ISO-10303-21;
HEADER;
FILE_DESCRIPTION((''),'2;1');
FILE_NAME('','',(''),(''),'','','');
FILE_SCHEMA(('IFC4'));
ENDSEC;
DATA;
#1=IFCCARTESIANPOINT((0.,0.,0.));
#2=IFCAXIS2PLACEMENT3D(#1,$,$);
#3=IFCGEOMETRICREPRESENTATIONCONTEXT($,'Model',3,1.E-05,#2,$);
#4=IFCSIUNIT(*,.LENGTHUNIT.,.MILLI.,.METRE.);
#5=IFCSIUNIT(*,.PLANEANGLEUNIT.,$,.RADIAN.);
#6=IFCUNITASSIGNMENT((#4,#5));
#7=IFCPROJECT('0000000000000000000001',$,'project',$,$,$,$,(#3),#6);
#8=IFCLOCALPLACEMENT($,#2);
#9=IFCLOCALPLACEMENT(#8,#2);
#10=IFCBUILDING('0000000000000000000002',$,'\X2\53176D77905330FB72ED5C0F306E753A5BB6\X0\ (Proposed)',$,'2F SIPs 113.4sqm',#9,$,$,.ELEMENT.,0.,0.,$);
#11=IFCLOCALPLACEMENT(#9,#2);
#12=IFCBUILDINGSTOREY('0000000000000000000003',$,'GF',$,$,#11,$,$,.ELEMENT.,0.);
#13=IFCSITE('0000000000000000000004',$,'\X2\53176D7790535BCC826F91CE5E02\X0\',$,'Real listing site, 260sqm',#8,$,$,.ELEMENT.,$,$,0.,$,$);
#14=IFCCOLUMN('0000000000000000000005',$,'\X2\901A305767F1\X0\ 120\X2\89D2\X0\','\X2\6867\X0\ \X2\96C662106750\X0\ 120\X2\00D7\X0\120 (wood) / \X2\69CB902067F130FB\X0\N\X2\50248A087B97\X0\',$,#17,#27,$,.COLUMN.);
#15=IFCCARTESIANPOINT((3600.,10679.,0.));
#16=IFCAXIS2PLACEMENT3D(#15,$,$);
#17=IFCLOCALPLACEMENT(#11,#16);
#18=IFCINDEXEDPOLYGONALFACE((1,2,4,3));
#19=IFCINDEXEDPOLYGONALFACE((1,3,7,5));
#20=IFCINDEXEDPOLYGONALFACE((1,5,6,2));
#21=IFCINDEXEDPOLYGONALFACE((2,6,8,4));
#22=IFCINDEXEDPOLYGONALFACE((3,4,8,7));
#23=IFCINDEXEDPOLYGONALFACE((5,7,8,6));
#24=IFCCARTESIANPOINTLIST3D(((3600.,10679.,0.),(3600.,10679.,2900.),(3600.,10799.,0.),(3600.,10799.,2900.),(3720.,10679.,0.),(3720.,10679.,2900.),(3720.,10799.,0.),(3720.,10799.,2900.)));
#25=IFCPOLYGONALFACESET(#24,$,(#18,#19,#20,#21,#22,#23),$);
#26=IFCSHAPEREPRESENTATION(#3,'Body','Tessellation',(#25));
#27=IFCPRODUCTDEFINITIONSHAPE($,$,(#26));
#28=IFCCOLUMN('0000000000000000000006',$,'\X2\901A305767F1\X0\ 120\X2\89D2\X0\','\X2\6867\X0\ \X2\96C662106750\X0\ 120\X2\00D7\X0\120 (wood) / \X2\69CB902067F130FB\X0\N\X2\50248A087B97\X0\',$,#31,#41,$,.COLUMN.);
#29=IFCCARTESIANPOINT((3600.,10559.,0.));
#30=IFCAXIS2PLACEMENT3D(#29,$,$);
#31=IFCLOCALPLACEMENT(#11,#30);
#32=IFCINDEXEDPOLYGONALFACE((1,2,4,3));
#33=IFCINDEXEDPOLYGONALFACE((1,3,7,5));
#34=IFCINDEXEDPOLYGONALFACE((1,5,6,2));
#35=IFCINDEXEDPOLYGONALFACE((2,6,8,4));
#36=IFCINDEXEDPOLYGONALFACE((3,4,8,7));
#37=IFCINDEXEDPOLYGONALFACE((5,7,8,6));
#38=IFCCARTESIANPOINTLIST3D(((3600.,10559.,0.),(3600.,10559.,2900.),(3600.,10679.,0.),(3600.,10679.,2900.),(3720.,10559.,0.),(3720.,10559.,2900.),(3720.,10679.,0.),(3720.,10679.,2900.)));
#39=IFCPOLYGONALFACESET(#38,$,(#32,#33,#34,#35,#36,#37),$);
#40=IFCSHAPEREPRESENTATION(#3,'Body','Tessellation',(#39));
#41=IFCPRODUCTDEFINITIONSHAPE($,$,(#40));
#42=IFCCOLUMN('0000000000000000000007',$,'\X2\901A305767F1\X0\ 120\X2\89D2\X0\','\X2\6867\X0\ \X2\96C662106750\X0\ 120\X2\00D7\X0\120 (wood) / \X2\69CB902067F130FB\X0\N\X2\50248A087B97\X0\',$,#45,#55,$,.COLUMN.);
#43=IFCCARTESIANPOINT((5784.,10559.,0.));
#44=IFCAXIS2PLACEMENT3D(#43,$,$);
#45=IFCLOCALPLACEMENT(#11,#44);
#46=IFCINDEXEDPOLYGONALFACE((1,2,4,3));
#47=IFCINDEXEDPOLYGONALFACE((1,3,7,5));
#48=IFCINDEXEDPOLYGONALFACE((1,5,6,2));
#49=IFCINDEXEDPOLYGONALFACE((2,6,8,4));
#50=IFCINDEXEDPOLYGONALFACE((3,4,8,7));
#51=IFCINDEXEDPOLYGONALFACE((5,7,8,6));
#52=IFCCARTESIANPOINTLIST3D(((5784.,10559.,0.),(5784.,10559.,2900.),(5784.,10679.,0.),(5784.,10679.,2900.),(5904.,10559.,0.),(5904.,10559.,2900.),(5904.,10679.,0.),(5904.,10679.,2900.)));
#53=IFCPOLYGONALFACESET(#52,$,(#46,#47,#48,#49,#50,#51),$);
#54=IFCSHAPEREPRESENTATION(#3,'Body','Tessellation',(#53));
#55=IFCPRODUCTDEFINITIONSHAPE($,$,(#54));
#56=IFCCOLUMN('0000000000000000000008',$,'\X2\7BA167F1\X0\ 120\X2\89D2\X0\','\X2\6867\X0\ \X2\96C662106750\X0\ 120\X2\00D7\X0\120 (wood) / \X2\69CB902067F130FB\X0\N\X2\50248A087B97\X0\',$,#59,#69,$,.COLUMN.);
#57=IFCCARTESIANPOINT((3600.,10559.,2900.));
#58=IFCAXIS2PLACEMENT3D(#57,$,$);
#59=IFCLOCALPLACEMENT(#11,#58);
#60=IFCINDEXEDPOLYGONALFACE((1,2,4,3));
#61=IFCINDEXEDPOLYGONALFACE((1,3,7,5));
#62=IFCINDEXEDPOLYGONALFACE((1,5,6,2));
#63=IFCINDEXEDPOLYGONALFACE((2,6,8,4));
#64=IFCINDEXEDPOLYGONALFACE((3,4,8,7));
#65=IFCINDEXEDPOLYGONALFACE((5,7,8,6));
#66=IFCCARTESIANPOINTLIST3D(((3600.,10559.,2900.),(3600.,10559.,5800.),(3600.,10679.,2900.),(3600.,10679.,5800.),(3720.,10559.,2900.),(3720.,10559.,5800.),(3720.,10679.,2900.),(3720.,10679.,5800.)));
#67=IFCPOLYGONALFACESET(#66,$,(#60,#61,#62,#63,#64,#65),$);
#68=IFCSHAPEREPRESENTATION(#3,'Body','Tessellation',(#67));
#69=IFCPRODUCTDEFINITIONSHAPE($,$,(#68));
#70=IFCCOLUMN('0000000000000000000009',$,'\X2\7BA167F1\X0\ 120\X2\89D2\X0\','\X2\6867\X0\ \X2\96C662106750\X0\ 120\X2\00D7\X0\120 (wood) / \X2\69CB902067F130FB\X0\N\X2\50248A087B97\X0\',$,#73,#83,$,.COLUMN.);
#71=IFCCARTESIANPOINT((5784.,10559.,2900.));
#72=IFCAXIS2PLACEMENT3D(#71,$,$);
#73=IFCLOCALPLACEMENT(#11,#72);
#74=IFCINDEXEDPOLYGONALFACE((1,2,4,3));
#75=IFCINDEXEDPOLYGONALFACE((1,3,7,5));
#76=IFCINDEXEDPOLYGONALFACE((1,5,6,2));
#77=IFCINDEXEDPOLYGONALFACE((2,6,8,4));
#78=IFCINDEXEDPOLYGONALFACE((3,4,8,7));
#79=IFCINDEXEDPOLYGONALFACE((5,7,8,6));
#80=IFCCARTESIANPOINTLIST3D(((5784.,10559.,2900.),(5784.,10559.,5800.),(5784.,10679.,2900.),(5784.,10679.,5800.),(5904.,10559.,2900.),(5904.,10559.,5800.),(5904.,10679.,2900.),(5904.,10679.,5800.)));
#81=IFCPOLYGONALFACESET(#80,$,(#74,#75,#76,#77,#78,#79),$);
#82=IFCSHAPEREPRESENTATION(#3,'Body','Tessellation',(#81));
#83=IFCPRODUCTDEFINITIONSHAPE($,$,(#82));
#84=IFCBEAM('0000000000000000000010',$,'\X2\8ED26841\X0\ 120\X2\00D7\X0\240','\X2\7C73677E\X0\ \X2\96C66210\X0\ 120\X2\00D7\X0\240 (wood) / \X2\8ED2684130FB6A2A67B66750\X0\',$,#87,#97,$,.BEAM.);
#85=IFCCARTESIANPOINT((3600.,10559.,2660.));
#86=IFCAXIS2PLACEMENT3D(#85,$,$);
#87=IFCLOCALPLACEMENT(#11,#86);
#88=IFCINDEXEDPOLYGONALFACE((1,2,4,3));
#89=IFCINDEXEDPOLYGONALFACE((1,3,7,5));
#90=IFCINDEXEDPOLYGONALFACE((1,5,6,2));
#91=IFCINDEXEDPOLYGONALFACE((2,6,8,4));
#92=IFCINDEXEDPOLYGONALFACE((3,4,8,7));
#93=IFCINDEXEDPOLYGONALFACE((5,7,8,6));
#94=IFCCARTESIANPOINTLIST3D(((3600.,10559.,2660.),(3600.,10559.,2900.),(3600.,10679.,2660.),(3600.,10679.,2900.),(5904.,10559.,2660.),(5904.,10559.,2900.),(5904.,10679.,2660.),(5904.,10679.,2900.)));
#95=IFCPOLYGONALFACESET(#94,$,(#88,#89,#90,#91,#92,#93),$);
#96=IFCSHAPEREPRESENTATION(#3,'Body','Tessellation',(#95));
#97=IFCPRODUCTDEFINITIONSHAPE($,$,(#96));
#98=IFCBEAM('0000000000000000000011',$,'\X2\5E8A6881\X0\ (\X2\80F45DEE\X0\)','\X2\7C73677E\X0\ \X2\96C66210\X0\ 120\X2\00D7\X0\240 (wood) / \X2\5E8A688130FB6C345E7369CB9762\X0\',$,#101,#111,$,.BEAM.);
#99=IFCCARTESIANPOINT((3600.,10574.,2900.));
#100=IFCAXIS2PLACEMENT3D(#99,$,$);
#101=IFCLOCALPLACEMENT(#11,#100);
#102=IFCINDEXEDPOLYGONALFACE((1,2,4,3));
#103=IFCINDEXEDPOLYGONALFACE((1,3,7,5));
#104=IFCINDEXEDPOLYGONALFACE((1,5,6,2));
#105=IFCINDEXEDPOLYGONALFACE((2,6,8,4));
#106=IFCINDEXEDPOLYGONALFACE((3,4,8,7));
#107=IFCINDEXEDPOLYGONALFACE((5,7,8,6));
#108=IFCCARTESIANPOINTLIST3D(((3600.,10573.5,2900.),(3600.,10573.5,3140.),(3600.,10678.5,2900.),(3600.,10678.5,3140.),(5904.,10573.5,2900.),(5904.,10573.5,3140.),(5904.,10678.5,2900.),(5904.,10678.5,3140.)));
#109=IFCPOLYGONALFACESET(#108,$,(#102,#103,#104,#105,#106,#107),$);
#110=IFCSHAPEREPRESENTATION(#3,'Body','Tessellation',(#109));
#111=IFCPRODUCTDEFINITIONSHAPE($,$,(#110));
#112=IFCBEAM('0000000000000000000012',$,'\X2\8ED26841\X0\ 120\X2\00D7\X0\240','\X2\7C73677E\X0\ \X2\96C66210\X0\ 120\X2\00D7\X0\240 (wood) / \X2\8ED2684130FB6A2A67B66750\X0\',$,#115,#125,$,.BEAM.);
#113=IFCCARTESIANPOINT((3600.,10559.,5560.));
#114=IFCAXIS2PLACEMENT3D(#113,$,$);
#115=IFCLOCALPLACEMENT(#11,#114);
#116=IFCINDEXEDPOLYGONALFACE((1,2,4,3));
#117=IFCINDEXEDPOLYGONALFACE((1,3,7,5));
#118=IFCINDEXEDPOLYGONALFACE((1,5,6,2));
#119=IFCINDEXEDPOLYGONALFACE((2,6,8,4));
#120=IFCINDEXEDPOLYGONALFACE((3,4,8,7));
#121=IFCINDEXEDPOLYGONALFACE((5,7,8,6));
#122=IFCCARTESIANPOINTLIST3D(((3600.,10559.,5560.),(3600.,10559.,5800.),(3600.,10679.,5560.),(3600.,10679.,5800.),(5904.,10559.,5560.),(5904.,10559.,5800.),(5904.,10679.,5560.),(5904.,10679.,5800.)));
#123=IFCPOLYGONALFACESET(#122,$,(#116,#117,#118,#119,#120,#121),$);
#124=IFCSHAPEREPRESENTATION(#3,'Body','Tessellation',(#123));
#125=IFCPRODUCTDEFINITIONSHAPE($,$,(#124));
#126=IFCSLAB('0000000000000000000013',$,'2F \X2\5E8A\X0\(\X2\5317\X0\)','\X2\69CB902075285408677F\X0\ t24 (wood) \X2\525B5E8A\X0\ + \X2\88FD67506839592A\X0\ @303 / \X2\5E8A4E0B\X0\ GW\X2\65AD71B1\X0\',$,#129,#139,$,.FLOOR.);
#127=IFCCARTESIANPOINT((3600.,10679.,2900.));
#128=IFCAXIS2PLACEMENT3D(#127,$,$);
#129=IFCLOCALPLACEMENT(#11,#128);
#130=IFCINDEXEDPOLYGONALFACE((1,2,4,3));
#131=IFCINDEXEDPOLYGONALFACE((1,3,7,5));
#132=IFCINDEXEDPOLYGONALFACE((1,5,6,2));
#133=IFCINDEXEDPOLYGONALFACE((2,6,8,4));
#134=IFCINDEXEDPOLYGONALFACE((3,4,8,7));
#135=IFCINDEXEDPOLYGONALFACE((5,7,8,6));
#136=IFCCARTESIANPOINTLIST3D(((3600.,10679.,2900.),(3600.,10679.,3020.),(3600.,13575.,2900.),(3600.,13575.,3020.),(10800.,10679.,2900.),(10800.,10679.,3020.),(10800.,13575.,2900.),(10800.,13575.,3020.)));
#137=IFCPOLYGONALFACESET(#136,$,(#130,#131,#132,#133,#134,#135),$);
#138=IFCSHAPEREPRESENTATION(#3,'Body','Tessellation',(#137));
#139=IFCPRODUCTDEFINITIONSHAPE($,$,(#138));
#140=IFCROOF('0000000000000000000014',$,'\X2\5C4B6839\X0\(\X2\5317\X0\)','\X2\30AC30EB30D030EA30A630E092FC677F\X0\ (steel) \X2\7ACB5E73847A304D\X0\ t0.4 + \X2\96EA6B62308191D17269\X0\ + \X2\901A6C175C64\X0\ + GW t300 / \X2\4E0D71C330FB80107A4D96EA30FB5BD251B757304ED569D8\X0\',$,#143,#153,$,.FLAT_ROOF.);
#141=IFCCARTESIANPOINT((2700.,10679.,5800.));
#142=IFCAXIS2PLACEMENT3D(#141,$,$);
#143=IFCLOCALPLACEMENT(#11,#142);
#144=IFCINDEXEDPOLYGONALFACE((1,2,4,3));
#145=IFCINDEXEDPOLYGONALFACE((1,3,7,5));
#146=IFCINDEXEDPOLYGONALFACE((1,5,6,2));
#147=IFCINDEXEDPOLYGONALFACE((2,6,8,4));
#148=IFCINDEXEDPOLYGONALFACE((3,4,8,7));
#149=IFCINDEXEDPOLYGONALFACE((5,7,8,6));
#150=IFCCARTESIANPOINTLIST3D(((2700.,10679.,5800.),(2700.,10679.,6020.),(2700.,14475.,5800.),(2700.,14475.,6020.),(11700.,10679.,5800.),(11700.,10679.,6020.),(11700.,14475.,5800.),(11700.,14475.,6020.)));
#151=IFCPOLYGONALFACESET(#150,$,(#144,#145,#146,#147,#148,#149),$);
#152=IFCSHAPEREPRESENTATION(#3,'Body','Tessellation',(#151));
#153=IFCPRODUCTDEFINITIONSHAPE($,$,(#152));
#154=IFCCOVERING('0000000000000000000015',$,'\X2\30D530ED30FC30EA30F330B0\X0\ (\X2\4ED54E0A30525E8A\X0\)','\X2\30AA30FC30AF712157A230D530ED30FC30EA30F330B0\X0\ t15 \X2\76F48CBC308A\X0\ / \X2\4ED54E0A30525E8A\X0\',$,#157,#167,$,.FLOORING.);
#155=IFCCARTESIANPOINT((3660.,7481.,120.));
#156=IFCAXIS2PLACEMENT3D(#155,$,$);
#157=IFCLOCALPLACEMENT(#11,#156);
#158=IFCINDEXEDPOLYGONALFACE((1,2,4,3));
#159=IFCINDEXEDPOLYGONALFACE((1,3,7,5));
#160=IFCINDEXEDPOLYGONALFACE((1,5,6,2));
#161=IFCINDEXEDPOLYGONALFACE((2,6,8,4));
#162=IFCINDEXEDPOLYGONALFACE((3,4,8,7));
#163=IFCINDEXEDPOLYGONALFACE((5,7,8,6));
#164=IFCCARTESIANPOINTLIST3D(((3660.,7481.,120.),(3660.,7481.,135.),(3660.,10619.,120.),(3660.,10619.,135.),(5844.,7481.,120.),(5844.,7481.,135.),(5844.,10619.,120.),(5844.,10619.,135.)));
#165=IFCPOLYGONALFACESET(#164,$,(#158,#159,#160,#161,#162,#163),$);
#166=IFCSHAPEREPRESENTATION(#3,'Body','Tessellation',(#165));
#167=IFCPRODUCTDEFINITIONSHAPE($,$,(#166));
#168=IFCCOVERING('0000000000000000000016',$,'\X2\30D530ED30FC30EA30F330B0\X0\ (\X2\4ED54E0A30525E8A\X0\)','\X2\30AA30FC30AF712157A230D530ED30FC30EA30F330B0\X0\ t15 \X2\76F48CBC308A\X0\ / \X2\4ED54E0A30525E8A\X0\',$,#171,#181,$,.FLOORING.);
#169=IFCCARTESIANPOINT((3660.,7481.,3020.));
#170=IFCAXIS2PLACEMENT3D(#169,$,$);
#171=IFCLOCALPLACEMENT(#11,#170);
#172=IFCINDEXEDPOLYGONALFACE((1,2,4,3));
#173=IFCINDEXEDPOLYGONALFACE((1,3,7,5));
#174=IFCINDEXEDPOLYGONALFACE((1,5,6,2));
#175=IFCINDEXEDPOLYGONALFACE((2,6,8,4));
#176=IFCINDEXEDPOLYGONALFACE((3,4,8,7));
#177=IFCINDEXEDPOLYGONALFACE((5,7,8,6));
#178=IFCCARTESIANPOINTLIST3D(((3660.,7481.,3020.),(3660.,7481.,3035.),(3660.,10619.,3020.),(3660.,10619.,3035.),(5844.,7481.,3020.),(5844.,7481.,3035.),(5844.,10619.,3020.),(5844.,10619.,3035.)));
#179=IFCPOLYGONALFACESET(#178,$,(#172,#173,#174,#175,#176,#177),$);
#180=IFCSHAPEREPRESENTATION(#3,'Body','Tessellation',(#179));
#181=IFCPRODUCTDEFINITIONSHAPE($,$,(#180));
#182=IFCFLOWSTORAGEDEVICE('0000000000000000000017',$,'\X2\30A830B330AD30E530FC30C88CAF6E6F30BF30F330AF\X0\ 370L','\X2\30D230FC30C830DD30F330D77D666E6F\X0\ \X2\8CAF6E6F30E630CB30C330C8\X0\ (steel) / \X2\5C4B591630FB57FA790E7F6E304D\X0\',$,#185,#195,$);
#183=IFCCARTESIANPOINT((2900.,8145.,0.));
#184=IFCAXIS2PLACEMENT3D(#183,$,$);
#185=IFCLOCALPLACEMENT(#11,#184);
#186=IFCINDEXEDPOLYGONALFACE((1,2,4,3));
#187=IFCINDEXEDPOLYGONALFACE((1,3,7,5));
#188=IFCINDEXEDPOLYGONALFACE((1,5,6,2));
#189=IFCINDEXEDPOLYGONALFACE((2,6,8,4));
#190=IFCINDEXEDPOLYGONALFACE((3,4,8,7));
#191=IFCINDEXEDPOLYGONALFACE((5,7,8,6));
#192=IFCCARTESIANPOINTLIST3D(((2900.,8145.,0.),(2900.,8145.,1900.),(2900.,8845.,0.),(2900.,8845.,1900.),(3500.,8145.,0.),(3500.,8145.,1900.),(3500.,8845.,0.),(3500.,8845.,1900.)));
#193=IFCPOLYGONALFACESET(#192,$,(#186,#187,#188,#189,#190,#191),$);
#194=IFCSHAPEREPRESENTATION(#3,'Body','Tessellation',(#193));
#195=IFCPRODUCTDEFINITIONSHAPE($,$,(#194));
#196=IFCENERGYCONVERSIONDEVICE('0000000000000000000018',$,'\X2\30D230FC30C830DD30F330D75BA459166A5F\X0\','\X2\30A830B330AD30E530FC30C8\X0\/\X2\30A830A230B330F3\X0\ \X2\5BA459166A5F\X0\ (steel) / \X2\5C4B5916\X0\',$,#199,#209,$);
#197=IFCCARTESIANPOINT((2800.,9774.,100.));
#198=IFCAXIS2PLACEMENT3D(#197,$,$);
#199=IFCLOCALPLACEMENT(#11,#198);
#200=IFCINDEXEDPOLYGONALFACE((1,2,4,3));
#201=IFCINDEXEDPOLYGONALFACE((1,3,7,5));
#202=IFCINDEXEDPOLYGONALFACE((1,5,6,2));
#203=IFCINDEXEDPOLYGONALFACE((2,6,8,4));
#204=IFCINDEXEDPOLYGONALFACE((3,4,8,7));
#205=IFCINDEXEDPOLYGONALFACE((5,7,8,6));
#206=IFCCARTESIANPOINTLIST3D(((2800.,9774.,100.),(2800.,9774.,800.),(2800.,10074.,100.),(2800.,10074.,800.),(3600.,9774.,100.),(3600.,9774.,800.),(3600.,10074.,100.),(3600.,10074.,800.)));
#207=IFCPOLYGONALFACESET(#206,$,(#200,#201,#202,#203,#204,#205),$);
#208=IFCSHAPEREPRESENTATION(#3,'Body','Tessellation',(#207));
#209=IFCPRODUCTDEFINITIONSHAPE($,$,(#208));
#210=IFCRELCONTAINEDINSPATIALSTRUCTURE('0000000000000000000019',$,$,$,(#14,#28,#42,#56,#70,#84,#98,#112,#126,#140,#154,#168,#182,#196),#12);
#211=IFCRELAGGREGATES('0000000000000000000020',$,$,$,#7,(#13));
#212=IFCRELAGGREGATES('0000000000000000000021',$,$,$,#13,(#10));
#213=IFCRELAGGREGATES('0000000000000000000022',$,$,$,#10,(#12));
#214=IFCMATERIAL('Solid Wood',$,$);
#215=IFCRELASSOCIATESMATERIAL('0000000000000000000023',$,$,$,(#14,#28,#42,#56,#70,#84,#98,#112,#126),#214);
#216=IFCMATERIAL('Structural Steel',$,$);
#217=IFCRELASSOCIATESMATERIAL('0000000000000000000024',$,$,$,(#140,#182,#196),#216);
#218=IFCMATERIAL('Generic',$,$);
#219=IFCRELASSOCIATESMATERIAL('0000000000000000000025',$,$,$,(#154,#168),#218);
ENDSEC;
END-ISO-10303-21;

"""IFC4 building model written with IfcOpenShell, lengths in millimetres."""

from ifc_helpers import new_model, si_unit, frame, frame_2d, origin, place, context, project, spatial, rectangle, extrude, material, element, save


model = new_model("IFC4")

# Units and contexts
model_context = context("Model", 3, precision=1e-05, world=origin())
ifc_project = project(units=[si_unit("LENGTHUNIT", "METRE", prefix="MILLI"), si_unit("PLANEANGLEUNIT", "RADIAN")], contexts=[model_context])

# Site, building, storey
site_placement = place(None, origin())
site = spatial("IfcSite", under=ifc_project, at=site_placement, Name="北海道富良野市", ObjectType="Real listing site, 260sqm", CompositionType="ELEMENT", RefElevation=0.0)
building_placement = place(site_placement, origin())
building = spatial("IfcBuilding", under=site, at=building_placement, Name="北海道・狭小の町家 (Proposed)", ObjectType="2F SIPs 113.4sqm", CompositionType="ELEMENT", ElevationOfRefHeight=0.0, ElevationOfTerrain=0.0)
storey_placement = place(building_placement, origin())
storey = spatial("IfcBuildingStorey", under=building, at=storey_placement, Name="GF", CompositionType="ELEMENT", Elevation=0.0)

# Columns
ifc_material_1 = material(Name="Solid Wood")
column_1_placement = place(storey_placement, frame((3600.0, 10679.0, 0.0)))
element("IfcColumn", 1, at=column_1_placement, inside=storey, material=ifc_material_1, Name="通し柱 120角", Description="桧 集成材 120×120 (wood) / 構造柱・N値計算", PredefinedType="COLUMN", context=model_context, shape_type="SweptSolid", body=[
    extrude(rectangle(XDim=120.0, YDim=120.0, at=frame_2d((60.0, 60.0))), frame((3600.0, 10679.0, 0.0)), (0.0, 0.0, 1.0), 2900.0),
])
column_2_placement = place(storey_placement, frame((3600.0, 10559.0, 0.0)))
element("IfcColumn", 2, at=column_2_placement, inside=storey, material=ifc_material_1, Name="通し柱 120角", Description="桧 集成材 120×120 (wood) / 構造柱・N値計算", PredefinedType="COLUMN", context=model_context, shape_type="SweptSolid", body=[
    extrude(rectangle(XDim=120.0, YDim=120.0, at=frame_2d((60.0, 60.0))), frame((3600.0, 10559.0, 0.0)), (0.0, 0.0, 1.0), 2900.0),
])
column_3_placement = place(storey_placement, frame((5784.0, 10559.0, 0.0)))
element("IfcColumn", 3, at=column_3_placement, inside=storey, material=ifc_material_1, Name="通し柱 120角", Description="桧 集成材 120×120 (wood) / 構造柱・N値計算", PredefinedType="COLUMN", context=model_context, shape_type="SweptSolid", body=[
    extrude(rectangle(XDim=120.0, YDim=120.0, at=frame_2d((60.0, 60.0))), frame((5784.0, 10559.0, 0.0)), (0.0, 0.0, 1.0), 2900.0),
])
column_4_placement = place(storey_placement, frame((3600.0, 10559.0, 2900.0)))
element("IfcColumn", 4, at=column_4_placement, inside=storey, material=ifc_material_1, Name="管柱 120角", Description="桧 集成材 120×120 (wood) / 構造柱・N値計算", PredefinedType="COLUMN", context=model_context, shape_type="SweptSolid", body=[
    extrude(rectangle(XDim=120.0, YDim=120.0, at=frame_2d((60.0, 60.0))), frame((3600.0, 10559.0, 2900.0)), (0.0, 0.0, 1.0), 2900.0),
])
column_5_placement = place(storey_placement, frame((5784.0, 10559.0, 2900.0)))
element("IfcColumn", 5, at=column_5_placement, inside=storey, material=ifc_material_1, Name="管柱 120角", Description="桧 集成材 120×120 (wood) / 構造柱・N値計算", PredefinedType="COLUMN", context=model_context, shape_type="SweptSolid", body=[
    extrude(rectangle(XDim=120.0, YDim=120.0, at=frame_2d((60.0, 60.0))), frame((5784.0, 10559.0, 2900.0)), (0.0, 0.0, 1.0), 2900.0),
])

# Beams
beam_1_placement = place(storey_placement, frame((3600.0, 10559.0, 2660.0)))
element("IfcBeam", 6, at=beam_1_placement, inside=storey, material=ifc_material_1, Name="軒桁 120×240", Description="米松 集成 120×240 (wood) / 軒桁・横架材", PredefinedType="BEAM", context=model_context, shape_type="SweptSolid", body=[
    extrude(rectangle(XDim=2304.0, YDim=120.0, at=frame_2d((1152.0, 60.0))), frame((3600.0, 10559.0, 2660.0)), (0.0, 0.0, 1.0), 240.0),
])
beam_2_placement = place(storey_placement, frame((3600.0, 10574.0, 2900.0)))
element("IfcBeam", 7, at=beam_2_placement, inside=storey, material=ifc_material_1, Name="床梁 (胴差)", Description="米松 集成 120×240 (wood) / 床梁・水平構面", PredefinedType="BEAM", context=model_context, shape_type="SweptSolid", body=[
    extrude(rectangle(XDim=2304.0, YDim=105.0, at=frame_2d((1152.0, 52.0))), frame((3600.0, 10574.0, 2900.0)), (0.0, 0.0, 1.0), 240.0),
])
beam_3_placement = place(storey_placement, frame((3600.0, 10559.0, 5560.0)))
element("IfcBeam", 8, at=beam_3_placement, inside=storey, material=ifc_material_1, Name="軒桁 120×240", Description="米松 集成 120×240 (wood) / 軒桁・横架材", PredefinedType="BEAM", context=model_context, shape_type="SweptSolid", body=[
    extrude(rectangle(XDim=2304.0, YDim=120.0, at=frame_2d((1152.0, 60.0))), frame((3600.0, 10559.0, 5560.0)), (0.0, 0.0, 1.0), 240.0),
])

# Slab
slab_1_placement = place(storey_placement, frame((3600.0, 10679.0, 2900.0)))
element("IfcSlab", 9, at=slab_1_placement, inside=storey, material=ifc_material_1, Name="2F 床(北)", Description="構造用合板 t24 (wood) 剛床 + 製材根太 @303 / 床下 GW断熱", PredefinedType="FLOOR", context=model_context, shape_type="SweptSolid", body=[
    extrude(rectangle(XDim=7200.0, YDim=2896.0, at=frame_2d((3600.0, 1448.0))), frame((3600.0, 10679.0, 2900.0)), (0.0, 0.0, 1.0), 120.0),
])

# Roof
ifc_material_2 = material(Name="Structural Steel")
for number, where, name in (
    (10, (2700.0, 10679.0, 5800.0), "屋根(北)"),
):
    element("IfcRoof", number, at=place(storey_placement, frame(where)), inside=storey, material=ifc_material_2, Name=name, Description="ガルバリウム鋼板 (steel) 立平葺き t0.4 + 雪止め金物 + 通気層 + GW t300 / 不燃・耐積雪・寒冷地仕様", PredefinedType="FLAT_ROOF", context=model_context, shape_type="SweptSolid", body=[
        extrude(rectangle(XDim=9000.0, YDim=3796.0, at=frame_2d((4500.0, 1898.0))), frame((2700.0, 10679.0, 5800.0)), (0.0, 0.0, 1.0), 220.0),
    ])

# Coverings
ifc_material_3 = material(Name="Generic")
covering_1_placement = place(storey_placement, frame((3660.0, 7481.0, 120.0)))
element("IfcCovering", 11, at=covering_1_placement, inside=storey, material=ifc_material_3, Name="フローリング (仕上げ床)", Description="オーク無垢フローリング t15 直貼り / 仕上げ床", PredefinedType="FLOORING", context=model_context, shape_type="SweptSolid", body=[
    extrude(rectangle(XDim=2184.0, YDim=3138.0, at=frame_2d((1092.0, 1569.0))), frame((3660.0, 7481.0, 120.0)), (0.0, 0.0, 1.0), 15.0),
])
covering_2_placement = place(storey_placement, frame((3660.0, 7481.0, 3020.0)))
element("IfcCovering", 12, at=covering_2_placement, inside=storey, material=ifc_material_3, Name="フローリング (仕上げ床)", Description="オーク無垢フローリング t15 直貼り / 仕上げ床", PredefinedType="FLOORING", context=model_context, shape_type="SweptSolid", body=[
    extrude(rectangle(XDim=2184.0, YDim=3138.0, at=frame_2d((1092.0, 1569.0))), frame((3660.0, 7481.0, 3020.0)), (0.0, 0.0, 1.0), 15.0),
])

# Flow storage device
flow_storage_device_placement = place(storey_placement, frame((2900.0, 8145.0, 0.0)))
element("IfcFlowStorageDevice", 13, at=flow_storage_device_placement, inside=storey, material=ifc_material_2, Name="エコキュート貯湯タンク 370L", Description="ヒートポンプ給湯 貯湯ユニット (steel) / 屋外・基礎置き", context=model_context, shape_type="SweptSolid", body=[
    extrude(rectangle(XDim=600.0, YDim=700.0, at=frame_2d((300.0, 350.0))), frame((2900.0, 8145.0, 0.0)), (0.0, 0.0, 1.0), 1900.0),
])

# Energy conversion device
energy_conversion_device_placement = place(storey_placement, frame((2800.0, 9774.0, 100.0)))
element("IfcEnergyConversionDevice", 14, at=energy_conversion_device_placement, inside=storey, material=ifc_material_2, Name="ヒートポンプ室外機", Description="エコキュート/エアコン 室外機 (steel) / 屋外", context=model_context, shape_type="SweptSolid", body=[
    extrude(rectangle(XDim=800.0, YDim=300.0, at=frame_2d((400.0, 150.0))), frame((2800.0, 9774.0, 100.0)), (0.0, 0.0, 1.0), 700.0),
])

save(model, "model.ifc")
